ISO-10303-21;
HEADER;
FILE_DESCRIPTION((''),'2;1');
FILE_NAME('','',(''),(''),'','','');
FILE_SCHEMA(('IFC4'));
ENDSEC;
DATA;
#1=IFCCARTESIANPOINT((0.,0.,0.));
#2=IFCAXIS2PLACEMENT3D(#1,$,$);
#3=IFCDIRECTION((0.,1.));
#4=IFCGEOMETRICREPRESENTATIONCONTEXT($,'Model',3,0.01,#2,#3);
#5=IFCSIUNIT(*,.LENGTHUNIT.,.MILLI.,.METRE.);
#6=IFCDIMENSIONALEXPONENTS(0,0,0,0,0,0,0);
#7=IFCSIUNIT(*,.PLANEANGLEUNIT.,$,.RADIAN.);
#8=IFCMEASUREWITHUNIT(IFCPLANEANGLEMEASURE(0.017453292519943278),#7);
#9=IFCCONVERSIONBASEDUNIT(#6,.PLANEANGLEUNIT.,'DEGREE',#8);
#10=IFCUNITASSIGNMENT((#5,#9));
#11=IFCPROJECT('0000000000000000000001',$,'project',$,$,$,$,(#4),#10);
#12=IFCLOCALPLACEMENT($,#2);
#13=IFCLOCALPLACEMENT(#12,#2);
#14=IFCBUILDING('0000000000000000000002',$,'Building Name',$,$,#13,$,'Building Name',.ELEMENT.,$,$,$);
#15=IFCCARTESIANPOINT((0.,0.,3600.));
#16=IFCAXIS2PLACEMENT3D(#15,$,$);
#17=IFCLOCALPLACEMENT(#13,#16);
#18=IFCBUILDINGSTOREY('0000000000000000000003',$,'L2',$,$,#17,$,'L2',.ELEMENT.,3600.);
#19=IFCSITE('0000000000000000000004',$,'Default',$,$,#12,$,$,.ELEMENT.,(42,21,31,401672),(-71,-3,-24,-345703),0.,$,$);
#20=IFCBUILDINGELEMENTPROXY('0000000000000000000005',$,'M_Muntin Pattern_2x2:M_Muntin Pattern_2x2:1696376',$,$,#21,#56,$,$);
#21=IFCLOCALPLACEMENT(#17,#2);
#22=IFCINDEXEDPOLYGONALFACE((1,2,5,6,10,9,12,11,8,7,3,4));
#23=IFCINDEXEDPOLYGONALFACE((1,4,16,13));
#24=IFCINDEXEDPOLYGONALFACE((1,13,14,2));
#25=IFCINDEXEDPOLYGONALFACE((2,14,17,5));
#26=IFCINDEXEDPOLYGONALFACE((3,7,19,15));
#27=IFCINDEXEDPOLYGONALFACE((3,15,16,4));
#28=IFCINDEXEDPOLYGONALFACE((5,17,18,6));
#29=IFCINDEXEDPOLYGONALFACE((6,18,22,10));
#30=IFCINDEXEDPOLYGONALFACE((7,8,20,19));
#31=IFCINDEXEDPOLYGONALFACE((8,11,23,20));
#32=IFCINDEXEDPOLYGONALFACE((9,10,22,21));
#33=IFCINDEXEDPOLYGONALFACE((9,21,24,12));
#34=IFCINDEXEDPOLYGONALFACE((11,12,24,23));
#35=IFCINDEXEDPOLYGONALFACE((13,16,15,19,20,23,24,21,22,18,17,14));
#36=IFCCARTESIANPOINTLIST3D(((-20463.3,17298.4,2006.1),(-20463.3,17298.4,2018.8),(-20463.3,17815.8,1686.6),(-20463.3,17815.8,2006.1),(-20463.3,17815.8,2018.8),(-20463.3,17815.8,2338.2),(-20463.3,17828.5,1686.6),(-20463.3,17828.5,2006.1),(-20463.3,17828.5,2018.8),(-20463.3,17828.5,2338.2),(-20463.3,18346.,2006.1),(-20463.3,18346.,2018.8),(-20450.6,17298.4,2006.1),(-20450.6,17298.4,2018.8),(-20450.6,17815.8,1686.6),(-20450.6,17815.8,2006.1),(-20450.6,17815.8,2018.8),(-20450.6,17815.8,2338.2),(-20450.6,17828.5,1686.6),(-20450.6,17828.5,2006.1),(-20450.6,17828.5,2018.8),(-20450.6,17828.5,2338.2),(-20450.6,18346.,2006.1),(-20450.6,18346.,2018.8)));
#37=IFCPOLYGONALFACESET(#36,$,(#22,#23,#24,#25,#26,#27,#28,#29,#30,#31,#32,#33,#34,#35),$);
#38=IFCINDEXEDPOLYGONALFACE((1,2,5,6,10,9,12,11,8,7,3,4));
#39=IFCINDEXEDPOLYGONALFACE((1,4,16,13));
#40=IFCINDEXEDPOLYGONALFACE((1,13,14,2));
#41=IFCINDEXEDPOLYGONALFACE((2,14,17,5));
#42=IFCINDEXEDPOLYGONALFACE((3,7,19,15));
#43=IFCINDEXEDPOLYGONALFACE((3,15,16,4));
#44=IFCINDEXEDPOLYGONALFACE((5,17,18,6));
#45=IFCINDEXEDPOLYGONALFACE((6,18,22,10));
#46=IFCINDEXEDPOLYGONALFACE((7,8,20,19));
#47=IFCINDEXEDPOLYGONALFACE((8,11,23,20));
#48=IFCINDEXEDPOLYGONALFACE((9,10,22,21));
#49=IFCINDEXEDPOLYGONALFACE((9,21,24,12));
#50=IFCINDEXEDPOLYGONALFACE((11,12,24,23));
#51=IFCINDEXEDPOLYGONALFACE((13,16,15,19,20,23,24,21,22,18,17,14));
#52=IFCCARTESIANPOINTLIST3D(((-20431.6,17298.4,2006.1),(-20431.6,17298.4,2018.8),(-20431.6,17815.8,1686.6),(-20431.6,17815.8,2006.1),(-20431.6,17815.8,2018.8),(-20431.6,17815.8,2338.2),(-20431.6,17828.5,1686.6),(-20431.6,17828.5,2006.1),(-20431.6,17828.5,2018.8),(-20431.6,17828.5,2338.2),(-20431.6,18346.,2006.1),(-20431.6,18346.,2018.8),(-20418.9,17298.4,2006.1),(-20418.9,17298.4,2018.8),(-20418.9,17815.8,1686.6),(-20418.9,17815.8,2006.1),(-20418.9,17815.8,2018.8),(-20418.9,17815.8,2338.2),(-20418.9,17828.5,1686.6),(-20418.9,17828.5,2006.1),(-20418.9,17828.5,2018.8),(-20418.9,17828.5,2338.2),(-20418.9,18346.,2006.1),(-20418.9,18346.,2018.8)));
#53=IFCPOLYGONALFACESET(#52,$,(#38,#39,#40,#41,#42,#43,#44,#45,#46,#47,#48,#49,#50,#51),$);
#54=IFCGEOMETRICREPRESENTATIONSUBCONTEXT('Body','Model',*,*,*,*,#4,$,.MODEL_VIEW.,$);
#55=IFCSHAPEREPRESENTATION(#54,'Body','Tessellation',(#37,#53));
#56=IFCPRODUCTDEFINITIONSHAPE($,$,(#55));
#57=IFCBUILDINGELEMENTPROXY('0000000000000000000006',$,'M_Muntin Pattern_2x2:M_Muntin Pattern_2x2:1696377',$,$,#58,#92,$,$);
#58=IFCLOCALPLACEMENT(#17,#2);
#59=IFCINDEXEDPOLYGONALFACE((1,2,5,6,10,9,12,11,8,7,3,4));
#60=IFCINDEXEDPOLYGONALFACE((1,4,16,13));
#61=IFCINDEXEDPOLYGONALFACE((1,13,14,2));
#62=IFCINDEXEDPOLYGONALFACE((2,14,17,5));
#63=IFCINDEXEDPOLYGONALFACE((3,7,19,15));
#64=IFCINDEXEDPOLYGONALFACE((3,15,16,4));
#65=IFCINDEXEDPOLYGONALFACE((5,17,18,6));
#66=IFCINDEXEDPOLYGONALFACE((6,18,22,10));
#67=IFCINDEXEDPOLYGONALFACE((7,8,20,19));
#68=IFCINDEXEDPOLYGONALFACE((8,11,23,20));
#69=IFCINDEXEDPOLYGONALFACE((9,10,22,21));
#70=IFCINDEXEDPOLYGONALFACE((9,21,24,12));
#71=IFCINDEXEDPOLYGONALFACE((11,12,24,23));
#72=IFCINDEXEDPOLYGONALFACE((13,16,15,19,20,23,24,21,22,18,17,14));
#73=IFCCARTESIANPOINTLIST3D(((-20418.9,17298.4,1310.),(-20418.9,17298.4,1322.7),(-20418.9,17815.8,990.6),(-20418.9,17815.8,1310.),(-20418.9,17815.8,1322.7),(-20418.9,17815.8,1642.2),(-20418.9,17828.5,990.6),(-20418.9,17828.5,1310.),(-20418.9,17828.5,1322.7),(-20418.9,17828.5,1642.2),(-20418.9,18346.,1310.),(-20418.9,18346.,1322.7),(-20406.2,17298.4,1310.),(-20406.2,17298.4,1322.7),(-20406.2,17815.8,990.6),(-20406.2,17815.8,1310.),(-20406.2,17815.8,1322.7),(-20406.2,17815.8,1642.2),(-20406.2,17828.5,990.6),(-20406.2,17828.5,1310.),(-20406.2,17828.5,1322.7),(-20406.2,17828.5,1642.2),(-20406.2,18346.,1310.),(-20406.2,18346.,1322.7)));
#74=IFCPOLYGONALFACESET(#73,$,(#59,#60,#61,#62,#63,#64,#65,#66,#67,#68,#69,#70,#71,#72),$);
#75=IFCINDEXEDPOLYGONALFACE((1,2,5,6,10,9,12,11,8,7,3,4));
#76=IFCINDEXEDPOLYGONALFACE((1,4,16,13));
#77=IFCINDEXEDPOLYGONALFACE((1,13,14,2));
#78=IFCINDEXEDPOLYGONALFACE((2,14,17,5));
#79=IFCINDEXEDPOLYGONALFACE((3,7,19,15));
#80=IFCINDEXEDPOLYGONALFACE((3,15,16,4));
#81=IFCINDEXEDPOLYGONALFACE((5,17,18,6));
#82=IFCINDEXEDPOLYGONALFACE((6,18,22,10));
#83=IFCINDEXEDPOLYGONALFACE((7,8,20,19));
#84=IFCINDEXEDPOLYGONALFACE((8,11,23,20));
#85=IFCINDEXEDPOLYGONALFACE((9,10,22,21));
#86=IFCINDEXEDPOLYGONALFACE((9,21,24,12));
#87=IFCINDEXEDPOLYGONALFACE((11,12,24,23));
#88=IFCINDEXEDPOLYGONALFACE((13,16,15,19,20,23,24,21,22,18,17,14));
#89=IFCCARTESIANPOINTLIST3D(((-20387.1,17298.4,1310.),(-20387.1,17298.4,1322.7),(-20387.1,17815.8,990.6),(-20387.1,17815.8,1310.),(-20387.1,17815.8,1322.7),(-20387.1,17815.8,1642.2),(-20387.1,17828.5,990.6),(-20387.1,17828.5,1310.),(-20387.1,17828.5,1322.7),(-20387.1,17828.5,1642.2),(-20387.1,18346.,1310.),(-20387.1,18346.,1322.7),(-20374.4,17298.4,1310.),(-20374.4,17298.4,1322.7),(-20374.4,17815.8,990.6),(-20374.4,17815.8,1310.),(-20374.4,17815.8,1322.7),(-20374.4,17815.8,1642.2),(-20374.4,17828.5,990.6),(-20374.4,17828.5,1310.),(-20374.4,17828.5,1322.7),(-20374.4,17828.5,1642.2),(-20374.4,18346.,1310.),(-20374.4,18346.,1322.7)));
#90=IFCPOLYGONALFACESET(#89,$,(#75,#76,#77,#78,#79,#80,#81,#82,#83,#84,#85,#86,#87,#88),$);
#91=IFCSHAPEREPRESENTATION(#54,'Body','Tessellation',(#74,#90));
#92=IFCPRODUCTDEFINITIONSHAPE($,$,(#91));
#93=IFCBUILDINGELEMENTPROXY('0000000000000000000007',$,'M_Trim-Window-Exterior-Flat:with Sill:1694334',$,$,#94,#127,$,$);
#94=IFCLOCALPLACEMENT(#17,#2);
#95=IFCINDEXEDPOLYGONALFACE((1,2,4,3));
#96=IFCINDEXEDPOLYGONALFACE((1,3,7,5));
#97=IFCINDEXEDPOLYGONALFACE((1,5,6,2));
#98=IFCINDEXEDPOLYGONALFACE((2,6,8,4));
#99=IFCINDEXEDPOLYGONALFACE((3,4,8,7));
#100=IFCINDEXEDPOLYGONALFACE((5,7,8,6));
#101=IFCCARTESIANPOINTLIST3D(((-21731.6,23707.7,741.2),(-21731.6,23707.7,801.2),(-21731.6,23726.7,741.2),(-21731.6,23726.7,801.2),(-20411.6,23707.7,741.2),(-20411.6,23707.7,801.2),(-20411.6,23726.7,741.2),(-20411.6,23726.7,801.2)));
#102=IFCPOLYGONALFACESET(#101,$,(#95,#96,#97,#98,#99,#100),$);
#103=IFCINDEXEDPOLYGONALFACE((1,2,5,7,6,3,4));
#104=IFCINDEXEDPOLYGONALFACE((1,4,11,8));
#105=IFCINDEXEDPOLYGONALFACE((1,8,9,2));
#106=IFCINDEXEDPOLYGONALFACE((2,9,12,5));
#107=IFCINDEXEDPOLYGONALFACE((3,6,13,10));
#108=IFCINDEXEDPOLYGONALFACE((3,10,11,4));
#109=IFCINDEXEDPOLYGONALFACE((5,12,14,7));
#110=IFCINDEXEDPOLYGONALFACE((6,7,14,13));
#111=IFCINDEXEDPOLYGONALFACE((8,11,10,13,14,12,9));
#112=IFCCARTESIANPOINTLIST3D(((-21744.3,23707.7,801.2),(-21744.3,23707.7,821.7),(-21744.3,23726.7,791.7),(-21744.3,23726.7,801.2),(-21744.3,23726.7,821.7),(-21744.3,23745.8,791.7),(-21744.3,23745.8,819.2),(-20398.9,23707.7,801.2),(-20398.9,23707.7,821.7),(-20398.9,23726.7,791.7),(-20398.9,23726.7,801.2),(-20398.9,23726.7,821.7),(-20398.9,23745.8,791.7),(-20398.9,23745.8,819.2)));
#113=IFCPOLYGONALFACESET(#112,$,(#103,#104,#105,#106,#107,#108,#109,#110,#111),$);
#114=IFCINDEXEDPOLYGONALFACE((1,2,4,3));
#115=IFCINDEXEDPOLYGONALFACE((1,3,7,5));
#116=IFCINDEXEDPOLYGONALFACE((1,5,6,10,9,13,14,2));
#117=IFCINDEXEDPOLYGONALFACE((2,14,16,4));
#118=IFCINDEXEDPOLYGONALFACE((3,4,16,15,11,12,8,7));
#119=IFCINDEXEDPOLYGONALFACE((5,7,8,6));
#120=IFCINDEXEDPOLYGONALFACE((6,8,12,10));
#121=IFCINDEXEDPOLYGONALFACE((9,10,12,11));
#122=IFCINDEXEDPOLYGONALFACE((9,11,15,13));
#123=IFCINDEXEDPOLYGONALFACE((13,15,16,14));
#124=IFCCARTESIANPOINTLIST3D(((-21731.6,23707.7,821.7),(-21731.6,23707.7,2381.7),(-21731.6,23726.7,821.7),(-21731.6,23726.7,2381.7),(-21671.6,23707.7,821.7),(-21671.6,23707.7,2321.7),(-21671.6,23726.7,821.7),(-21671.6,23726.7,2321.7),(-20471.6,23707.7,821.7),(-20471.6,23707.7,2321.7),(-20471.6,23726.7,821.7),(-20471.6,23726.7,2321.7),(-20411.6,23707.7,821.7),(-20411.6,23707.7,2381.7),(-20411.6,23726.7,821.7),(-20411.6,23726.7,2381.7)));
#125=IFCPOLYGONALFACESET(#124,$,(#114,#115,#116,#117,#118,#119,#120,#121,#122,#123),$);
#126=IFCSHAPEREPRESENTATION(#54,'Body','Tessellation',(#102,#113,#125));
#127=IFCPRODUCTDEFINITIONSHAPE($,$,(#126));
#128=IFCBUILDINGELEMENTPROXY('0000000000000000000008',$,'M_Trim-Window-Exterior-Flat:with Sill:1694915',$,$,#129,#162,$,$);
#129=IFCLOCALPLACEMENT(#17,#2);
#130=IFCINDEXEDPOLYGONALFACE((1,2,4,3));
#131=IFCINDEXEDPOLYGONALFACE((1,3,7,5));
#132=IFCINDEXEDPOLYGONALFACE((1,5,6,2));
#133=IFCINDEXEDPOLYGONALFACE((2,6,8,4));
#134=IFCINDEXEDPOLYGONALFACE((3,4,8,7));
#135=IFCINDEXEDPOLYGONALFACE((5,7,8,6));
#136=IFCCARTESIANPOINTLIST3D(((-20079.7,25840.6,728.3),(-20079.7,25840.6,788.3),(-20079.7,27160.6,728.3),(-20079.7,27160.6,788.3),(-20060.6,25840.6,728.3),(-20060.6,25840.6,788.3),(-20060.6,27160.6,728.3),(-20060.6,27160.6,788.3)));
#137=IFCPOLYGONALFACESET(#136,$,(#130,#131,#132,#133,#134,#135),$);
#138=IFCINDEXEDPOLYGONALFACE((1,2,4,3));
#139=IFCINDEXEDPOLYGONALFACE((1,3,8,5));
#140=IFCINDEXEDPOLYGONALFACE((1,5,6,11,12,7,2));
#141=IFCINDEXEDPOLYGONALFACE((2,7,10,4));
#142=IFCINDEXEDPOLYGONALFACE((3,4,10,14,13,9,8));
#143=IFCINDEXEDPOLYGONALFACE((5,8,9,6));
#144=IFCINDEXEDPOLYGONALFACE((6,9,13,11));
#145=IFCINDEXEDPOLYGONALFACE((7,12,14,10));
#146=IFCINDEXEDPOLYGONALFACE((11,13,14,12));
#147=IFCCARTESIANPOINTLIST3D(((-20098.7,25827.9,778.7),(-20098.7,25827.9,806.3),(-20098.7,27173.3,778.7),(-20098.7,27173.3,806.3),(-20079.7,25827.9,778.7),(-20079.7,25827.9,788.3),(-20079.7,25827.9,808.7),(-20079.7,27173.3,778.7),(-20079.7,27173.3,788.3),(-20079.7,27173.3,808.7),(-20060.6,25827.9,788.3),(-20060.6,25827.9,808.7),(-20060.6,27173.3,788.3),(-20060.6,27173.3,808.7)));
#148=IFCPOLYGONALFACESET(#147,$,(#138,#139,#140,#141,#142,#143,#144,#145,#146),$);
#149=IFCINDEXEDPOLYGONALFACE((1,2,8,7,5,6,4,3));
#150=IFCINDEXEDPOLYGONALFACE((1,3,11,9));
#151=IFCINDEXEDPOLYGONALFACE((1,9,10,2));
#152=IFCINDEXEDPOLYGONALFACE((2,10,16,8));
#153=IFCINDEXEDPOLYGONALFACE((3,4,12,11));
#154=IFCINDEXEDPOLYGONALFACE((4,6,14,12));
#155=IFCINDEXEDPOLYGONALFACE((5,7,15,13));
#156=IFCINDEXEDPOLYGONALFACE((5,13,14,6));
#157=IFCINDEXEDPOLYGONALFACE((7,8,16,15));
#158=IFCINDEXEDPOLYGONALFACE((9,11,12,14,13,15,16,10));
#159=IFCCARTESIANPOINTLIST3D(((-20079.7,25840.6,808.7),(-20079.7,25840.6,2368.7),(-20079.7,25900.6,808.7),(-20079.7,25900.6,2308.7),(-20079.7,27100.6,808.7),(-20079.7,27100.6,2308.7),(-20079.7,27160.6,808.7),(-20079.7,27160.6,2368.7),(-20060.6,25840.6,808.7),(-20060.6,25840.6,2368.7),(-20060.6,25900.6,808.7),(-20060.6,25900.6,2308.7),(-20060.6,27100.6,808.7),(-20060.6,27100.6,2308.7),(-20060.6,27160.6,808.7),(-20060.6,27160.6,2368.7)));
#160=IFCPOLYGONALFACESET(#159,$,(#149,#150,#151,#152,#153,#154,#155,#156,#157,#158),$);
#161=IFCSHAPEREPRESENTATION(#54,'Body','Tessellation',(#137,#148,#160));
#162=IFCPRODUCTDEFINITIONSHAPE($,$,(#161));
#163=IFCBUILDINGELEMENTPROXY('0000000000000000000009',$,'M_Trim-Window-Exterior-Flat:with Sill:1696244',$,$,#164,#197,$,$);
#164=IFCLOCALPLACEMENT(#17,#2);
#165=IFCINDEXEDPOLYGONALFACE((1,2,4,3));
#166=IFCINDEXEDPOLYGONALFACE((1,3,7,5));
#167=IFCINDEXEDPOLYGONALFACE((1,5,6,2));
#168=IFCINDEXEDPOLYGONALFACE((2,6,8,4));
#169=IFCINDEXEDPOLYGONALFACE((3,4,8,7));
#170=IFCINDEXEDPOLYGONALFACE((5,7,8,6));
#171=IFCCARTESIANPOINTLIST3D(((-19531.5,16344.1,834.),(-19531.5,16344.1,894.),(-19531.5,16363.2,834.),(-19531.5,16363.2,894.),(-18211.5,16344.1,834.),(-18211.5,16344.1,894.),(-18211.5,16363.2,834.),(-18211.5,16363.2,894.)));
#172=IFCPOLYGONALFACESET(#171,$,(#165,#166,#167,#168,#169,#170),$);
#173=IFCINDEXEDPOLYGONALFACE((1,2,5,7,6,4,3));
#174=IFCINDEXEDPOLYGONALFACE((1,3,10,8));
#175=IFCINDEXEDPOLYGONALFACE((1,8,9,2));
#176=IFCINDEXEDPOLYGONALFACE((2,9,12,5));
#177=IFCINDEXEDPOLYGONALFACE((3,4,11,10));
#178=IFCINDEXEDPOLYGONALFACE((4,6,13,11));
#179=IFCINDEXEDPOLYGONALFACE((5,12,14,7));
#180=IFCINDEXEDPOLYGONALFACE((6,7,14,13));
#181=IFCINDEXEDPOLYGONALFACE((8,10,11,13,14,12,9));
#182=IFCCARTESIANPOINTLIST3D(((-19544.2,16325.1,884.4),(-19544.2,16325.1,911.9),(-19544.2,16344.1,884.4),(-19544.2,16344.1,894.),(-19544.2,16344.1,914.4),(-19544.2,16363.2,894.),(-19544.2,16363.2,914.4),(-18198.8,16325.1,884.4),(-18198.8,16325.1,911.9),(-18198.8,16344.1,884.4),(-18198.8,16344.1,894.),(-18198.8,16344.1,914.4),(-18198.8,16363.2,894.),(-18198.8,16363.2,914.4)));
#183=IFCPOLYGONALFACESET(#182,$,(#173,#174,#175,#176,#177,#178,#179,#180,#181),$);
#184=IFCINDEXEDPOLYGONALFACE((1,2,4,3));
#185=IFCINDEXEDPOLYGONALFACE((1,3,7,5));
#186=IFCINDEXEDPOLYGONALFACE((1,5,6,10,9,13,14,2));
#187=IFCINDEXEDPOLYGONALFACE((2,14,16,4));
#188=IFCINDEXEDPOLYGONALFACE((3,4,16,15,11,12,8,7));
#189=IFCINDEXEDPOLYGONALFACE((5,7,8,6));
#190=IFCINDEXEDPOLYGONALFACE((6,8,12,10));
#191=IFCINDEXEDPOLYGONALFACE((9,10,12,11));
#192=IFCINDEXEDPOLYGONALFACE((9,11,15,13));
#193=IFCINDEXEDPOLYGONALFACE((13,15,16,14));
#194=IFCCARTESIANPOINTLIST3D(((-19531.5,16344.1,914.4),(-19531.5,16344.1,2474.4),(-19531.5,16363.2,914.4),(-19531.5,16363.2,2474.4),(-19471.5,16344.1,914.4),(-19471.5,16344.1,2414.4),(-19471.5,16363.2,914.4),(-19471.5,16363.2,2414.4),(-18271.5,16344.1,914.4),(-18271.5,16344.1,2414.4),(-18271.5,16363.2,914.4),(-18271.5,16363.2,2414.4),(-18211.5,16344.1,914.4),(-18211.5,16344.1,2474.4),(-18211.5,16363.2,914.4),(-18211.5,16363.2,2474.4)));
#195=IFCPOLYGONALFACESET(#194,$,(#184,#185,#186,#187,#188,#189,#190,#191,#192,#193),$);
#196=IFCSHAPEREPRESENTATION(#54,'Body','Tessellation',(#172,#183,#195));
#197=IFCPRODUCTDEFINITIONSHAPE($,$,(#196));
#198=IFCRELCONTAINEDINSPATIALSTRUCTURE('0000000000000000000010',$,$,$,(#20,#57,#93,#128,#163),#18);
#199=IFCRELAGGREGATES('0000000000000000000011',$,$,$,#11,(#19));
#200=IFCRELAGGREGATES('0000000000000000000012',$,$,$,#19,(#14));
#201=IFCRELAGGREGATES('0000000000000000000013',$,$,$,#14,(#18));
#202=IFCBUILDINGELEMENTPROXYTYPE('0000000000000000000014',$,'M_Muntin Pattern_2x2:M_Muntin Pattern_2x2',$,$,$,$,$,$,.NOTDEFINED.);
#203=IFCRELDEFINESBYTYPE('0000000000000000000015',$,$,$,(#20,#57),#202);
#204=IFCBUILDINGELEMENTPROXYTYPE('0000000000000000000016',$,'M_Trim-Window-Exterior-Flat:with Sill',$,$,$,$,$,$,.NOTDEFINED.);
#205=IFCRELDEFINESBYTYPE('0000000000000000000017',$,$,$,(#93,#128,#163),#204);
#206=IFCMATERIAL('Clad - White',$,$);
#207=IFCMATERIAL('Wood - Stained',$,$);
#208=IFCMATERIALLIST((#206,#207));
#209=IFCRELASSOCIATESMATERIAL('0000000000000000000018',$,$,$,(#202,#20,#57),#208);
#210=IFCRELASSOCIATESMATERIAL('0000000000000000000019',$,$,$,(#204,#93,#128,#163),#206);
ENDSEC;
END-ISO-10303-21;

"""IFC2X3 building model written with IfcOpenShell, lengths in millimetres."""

from ifc_helpers import new_model, entity, si_unit, converted_unit, direction, frame, frame_2d, origin, place, context, subcontext, project, spatial, polyline, rectangle, outline, extrude, source, transform, mapped, material, material_list, type_object, type_shapes, element, save


model = new_model("IFC2X3")

# Units and contexts
model_context = context("Model", 3, precision=0.01, world=origin(), true_north=direction((0.0, 1.0)))
body_context = subcontext(model_context, "Body", "Model", "MODEL_VIEW")
ifc_project = project(units=[si_unit("LENGTHUNIT", "METRE", prefix="MILLI"), converted_unit("PLANEANGLEUNIT", "DEGREE", entity("IfcPlaneAngleMeasure", 0.017453292519943278), si_unit("PLANEANGLEUNIT", "RADIAN"), dimensions=[0, 0, 0, 0, 0, 0, 0])], contexts=[model_context])

# Site, building, storey
site_placement = place(None, origin())
site = spatial("IfcSite", under=ifc_project, at=site_placement, Name="Default", CompositionType="ELEMENT", RefLatitude=(42, 21, 31, 401672), RefLongitude=(-71, -3, -24, -345703), RefElevation=0.0)
building_placement = place(site_placement, origin())
building = spatial("IfcBuilding", under=site, at=building_placement, Name="Building Name", LongName="Building Name", CompositionType="ELEMENT")
storey_placement = place(building_placement, frame((0.0, 0.0, 3600.0)))
storey = spatial("IfcBuildingStorey", under=building, at=storey_placement, Name="L2", LongName="L2", CompositionType="ELEMENT", Elevation=3600.0)

# Shared definitions
ifc_material_1 = material(Name="Wood - Stained")

# Building element proxies
ifc_material_2 = material(Name="Clad - White")
ifc_material_list_1 = material_list([ifc_material_2, ifc_material_1])
building_element_proxy_type_1 = type_object("IfcBuildingElementProxyType", Name="M_Muntin Pattern_2x2:M_Muntin Pattern_2x2", PredefinedType="NOTDEFINED", material=ifc_material_list_1)
shared_shape_1 = source(origin(), body_context, "Body", "SweptSolid", [
    extrude(outline(polyline([(6.4, -6.4), (325.8, -6.4), (325.8, 6.3), (6.4, 6.3), (6.4, 523.8), (-6.3, 523.8), (-6.3, 6.3), (-325.8, 6.3), (-325.8, -6.4), (-6.3, -6.4), (-6.3, -523.8), (6.4, -523.8), (6.4, -6.4)])), frame((0.0, 9.5, 325.8), z_axis=(0.0, 1.0, 0.0), x_axis=(0.0, 0.0, 1.0)), (0.0, 0.0, 1.0), 12.7),
    extrude(outline(polyline([(6.4, -6.4), (325.8, -6.4), (325.8, 6.3), (6.4, 6.3), (6.4, 523.8), (-6.3, 523.8), (-6.3, 6.3), (-325.8, 6.3), (-325.8, -6.4), (-6.3, -6.4), (-6.3, -523.8), (6.4, -523.8), (6.4, -6.4)])), frame((0.0, -22.2, 325.8), z_axis=(0.0, 1.0, 0.0), x_axis=(0.0, 0.0, 1.0)), (0.0, 0.0, 1.0), 12.7),
])
type_shapes(building_element_proxy_type_1, [shared_shape_1])
for number, where, z_axis, x_axis, name in (
    (1, (-20441.1, 17822.2, 1686.6), (0.0, 0.0, 1.0), (0.0, 1.0, 0.0), "M_Muntin Pattern_2x2:M_Muntin Pattern_2x2:1696376"),
    (2, (-20396.7, 17822.2, 990.6), (0.0, 0.0, 1.0), (0.0, 1.0, 0.0), "M_Muntin Pattern_2x2:M_Muntin Pattern_2x2:1696377"),
):
    element("IfcBuildingElementProxy", number, at=place(storey_placement, frame(where, z_axis=z_axis, x_axis=x_axis)), inside=storey, type_object=building_element_proxy_type_1, material=ifc_material_list_1, Name=name, context=body_context, shape_type="MappedRepresentation", body=[
        mapped(shared_shape_1, transform((0.0, 0.0, 0.0), scale=1.0)),
    ])
building_element_proxy_type_2 = type_object("IfcBuildingElementProxyType", Name="M_Trim-Window-Exterior-Flat:with Sill", PredefinedType="NOTDEFINED", material=ifc_material_2)
shared_shape_2 = source(origin(), body_context, "Body", "SweptSolid", [
    extrude(rectangle(XDim=1320.0, YDim=60.0, at=frame_2d((0.0, 0.0), x_axis=(1.0, 0.0))), frame((0.0, -1550.4, 0.0), z_axis=(0.0, 0.0, 1.0), x_axis=(-1.0, 0.0, 0.0)), (0.0, 0.0, 1.0), 19.0),
    extrude(outline(polyline([(-19.0, -15.2), (0.0, -15.2), (0.0, -5.7), (19.0, -5.7), (19.0, 14.8), (0.0, 14.8), (-19.0, 12.3), (-19.0, -15.2)])), frame((-672.7, -1514.8, 19.0), z_axis=(1.0, 0.0, 0.0), x_axis=(0.0, 0.0, -1.0)), (0.0, 0.0, 1.0), 1345.4),
    extrude(outline(polyline([(-795.0, -660.0), (765.0, -660.0), (765.0, -600.0), (-735.0, -600.0), (-735.0, 600.0), (765.0, 600.0), (765.0, 660.0), (-795.0, 660.0), (-795.0, -660.0)])), frame((0.0, -735.0, 0.0), z_axis=(0.0, 0.0, 1.0), x_axis=(0.0, -1.0, 0.0)), (0.0, 0.0, 1.0), 19.0),
])
type_shapes(building_element_proxy_type_2, [shared_shape_2])
for number, where, z_axis, x_axis, name in (
    (3, (-21071.6, 23707.7, 2321.7), (0.0, 1.0, 0.0), (-1.0, 0.0, 0.0), "M_Trim-Window-Exterior-Flat:with Sill:1694334"),
    (4, (-20060.6, 26500.6, 2308.7), (-1.0, 0.0, 0.0), (0.0, -1.0, 0.0), "M_Trim-Window-Exterior-Flat:with Sill:1694915"),
    (5, (-18871.5, 16363.2, 2414.4), (0.0, -1.0, 0.0), (1.0, 0.0, 0.0), "M_Trim-Window-Exterior-Flat:with Sill:1696244"),
):
    element("IfcBuildingElementProxy", number, at=place(storey_placement, frame(where, z_axis=z_axis, x_axis=x_axis)), inside=storey, type_object=building_element_proxy_type_2, material=ifc_material_2, Name=name, context=body_context, shape_type="MappedRepresentation", body=[
        mapped(shared_shape_2, transform((0.0, 0.0, 0.0), scale=1.0)),
    ])

save(model, "model.ifc")
